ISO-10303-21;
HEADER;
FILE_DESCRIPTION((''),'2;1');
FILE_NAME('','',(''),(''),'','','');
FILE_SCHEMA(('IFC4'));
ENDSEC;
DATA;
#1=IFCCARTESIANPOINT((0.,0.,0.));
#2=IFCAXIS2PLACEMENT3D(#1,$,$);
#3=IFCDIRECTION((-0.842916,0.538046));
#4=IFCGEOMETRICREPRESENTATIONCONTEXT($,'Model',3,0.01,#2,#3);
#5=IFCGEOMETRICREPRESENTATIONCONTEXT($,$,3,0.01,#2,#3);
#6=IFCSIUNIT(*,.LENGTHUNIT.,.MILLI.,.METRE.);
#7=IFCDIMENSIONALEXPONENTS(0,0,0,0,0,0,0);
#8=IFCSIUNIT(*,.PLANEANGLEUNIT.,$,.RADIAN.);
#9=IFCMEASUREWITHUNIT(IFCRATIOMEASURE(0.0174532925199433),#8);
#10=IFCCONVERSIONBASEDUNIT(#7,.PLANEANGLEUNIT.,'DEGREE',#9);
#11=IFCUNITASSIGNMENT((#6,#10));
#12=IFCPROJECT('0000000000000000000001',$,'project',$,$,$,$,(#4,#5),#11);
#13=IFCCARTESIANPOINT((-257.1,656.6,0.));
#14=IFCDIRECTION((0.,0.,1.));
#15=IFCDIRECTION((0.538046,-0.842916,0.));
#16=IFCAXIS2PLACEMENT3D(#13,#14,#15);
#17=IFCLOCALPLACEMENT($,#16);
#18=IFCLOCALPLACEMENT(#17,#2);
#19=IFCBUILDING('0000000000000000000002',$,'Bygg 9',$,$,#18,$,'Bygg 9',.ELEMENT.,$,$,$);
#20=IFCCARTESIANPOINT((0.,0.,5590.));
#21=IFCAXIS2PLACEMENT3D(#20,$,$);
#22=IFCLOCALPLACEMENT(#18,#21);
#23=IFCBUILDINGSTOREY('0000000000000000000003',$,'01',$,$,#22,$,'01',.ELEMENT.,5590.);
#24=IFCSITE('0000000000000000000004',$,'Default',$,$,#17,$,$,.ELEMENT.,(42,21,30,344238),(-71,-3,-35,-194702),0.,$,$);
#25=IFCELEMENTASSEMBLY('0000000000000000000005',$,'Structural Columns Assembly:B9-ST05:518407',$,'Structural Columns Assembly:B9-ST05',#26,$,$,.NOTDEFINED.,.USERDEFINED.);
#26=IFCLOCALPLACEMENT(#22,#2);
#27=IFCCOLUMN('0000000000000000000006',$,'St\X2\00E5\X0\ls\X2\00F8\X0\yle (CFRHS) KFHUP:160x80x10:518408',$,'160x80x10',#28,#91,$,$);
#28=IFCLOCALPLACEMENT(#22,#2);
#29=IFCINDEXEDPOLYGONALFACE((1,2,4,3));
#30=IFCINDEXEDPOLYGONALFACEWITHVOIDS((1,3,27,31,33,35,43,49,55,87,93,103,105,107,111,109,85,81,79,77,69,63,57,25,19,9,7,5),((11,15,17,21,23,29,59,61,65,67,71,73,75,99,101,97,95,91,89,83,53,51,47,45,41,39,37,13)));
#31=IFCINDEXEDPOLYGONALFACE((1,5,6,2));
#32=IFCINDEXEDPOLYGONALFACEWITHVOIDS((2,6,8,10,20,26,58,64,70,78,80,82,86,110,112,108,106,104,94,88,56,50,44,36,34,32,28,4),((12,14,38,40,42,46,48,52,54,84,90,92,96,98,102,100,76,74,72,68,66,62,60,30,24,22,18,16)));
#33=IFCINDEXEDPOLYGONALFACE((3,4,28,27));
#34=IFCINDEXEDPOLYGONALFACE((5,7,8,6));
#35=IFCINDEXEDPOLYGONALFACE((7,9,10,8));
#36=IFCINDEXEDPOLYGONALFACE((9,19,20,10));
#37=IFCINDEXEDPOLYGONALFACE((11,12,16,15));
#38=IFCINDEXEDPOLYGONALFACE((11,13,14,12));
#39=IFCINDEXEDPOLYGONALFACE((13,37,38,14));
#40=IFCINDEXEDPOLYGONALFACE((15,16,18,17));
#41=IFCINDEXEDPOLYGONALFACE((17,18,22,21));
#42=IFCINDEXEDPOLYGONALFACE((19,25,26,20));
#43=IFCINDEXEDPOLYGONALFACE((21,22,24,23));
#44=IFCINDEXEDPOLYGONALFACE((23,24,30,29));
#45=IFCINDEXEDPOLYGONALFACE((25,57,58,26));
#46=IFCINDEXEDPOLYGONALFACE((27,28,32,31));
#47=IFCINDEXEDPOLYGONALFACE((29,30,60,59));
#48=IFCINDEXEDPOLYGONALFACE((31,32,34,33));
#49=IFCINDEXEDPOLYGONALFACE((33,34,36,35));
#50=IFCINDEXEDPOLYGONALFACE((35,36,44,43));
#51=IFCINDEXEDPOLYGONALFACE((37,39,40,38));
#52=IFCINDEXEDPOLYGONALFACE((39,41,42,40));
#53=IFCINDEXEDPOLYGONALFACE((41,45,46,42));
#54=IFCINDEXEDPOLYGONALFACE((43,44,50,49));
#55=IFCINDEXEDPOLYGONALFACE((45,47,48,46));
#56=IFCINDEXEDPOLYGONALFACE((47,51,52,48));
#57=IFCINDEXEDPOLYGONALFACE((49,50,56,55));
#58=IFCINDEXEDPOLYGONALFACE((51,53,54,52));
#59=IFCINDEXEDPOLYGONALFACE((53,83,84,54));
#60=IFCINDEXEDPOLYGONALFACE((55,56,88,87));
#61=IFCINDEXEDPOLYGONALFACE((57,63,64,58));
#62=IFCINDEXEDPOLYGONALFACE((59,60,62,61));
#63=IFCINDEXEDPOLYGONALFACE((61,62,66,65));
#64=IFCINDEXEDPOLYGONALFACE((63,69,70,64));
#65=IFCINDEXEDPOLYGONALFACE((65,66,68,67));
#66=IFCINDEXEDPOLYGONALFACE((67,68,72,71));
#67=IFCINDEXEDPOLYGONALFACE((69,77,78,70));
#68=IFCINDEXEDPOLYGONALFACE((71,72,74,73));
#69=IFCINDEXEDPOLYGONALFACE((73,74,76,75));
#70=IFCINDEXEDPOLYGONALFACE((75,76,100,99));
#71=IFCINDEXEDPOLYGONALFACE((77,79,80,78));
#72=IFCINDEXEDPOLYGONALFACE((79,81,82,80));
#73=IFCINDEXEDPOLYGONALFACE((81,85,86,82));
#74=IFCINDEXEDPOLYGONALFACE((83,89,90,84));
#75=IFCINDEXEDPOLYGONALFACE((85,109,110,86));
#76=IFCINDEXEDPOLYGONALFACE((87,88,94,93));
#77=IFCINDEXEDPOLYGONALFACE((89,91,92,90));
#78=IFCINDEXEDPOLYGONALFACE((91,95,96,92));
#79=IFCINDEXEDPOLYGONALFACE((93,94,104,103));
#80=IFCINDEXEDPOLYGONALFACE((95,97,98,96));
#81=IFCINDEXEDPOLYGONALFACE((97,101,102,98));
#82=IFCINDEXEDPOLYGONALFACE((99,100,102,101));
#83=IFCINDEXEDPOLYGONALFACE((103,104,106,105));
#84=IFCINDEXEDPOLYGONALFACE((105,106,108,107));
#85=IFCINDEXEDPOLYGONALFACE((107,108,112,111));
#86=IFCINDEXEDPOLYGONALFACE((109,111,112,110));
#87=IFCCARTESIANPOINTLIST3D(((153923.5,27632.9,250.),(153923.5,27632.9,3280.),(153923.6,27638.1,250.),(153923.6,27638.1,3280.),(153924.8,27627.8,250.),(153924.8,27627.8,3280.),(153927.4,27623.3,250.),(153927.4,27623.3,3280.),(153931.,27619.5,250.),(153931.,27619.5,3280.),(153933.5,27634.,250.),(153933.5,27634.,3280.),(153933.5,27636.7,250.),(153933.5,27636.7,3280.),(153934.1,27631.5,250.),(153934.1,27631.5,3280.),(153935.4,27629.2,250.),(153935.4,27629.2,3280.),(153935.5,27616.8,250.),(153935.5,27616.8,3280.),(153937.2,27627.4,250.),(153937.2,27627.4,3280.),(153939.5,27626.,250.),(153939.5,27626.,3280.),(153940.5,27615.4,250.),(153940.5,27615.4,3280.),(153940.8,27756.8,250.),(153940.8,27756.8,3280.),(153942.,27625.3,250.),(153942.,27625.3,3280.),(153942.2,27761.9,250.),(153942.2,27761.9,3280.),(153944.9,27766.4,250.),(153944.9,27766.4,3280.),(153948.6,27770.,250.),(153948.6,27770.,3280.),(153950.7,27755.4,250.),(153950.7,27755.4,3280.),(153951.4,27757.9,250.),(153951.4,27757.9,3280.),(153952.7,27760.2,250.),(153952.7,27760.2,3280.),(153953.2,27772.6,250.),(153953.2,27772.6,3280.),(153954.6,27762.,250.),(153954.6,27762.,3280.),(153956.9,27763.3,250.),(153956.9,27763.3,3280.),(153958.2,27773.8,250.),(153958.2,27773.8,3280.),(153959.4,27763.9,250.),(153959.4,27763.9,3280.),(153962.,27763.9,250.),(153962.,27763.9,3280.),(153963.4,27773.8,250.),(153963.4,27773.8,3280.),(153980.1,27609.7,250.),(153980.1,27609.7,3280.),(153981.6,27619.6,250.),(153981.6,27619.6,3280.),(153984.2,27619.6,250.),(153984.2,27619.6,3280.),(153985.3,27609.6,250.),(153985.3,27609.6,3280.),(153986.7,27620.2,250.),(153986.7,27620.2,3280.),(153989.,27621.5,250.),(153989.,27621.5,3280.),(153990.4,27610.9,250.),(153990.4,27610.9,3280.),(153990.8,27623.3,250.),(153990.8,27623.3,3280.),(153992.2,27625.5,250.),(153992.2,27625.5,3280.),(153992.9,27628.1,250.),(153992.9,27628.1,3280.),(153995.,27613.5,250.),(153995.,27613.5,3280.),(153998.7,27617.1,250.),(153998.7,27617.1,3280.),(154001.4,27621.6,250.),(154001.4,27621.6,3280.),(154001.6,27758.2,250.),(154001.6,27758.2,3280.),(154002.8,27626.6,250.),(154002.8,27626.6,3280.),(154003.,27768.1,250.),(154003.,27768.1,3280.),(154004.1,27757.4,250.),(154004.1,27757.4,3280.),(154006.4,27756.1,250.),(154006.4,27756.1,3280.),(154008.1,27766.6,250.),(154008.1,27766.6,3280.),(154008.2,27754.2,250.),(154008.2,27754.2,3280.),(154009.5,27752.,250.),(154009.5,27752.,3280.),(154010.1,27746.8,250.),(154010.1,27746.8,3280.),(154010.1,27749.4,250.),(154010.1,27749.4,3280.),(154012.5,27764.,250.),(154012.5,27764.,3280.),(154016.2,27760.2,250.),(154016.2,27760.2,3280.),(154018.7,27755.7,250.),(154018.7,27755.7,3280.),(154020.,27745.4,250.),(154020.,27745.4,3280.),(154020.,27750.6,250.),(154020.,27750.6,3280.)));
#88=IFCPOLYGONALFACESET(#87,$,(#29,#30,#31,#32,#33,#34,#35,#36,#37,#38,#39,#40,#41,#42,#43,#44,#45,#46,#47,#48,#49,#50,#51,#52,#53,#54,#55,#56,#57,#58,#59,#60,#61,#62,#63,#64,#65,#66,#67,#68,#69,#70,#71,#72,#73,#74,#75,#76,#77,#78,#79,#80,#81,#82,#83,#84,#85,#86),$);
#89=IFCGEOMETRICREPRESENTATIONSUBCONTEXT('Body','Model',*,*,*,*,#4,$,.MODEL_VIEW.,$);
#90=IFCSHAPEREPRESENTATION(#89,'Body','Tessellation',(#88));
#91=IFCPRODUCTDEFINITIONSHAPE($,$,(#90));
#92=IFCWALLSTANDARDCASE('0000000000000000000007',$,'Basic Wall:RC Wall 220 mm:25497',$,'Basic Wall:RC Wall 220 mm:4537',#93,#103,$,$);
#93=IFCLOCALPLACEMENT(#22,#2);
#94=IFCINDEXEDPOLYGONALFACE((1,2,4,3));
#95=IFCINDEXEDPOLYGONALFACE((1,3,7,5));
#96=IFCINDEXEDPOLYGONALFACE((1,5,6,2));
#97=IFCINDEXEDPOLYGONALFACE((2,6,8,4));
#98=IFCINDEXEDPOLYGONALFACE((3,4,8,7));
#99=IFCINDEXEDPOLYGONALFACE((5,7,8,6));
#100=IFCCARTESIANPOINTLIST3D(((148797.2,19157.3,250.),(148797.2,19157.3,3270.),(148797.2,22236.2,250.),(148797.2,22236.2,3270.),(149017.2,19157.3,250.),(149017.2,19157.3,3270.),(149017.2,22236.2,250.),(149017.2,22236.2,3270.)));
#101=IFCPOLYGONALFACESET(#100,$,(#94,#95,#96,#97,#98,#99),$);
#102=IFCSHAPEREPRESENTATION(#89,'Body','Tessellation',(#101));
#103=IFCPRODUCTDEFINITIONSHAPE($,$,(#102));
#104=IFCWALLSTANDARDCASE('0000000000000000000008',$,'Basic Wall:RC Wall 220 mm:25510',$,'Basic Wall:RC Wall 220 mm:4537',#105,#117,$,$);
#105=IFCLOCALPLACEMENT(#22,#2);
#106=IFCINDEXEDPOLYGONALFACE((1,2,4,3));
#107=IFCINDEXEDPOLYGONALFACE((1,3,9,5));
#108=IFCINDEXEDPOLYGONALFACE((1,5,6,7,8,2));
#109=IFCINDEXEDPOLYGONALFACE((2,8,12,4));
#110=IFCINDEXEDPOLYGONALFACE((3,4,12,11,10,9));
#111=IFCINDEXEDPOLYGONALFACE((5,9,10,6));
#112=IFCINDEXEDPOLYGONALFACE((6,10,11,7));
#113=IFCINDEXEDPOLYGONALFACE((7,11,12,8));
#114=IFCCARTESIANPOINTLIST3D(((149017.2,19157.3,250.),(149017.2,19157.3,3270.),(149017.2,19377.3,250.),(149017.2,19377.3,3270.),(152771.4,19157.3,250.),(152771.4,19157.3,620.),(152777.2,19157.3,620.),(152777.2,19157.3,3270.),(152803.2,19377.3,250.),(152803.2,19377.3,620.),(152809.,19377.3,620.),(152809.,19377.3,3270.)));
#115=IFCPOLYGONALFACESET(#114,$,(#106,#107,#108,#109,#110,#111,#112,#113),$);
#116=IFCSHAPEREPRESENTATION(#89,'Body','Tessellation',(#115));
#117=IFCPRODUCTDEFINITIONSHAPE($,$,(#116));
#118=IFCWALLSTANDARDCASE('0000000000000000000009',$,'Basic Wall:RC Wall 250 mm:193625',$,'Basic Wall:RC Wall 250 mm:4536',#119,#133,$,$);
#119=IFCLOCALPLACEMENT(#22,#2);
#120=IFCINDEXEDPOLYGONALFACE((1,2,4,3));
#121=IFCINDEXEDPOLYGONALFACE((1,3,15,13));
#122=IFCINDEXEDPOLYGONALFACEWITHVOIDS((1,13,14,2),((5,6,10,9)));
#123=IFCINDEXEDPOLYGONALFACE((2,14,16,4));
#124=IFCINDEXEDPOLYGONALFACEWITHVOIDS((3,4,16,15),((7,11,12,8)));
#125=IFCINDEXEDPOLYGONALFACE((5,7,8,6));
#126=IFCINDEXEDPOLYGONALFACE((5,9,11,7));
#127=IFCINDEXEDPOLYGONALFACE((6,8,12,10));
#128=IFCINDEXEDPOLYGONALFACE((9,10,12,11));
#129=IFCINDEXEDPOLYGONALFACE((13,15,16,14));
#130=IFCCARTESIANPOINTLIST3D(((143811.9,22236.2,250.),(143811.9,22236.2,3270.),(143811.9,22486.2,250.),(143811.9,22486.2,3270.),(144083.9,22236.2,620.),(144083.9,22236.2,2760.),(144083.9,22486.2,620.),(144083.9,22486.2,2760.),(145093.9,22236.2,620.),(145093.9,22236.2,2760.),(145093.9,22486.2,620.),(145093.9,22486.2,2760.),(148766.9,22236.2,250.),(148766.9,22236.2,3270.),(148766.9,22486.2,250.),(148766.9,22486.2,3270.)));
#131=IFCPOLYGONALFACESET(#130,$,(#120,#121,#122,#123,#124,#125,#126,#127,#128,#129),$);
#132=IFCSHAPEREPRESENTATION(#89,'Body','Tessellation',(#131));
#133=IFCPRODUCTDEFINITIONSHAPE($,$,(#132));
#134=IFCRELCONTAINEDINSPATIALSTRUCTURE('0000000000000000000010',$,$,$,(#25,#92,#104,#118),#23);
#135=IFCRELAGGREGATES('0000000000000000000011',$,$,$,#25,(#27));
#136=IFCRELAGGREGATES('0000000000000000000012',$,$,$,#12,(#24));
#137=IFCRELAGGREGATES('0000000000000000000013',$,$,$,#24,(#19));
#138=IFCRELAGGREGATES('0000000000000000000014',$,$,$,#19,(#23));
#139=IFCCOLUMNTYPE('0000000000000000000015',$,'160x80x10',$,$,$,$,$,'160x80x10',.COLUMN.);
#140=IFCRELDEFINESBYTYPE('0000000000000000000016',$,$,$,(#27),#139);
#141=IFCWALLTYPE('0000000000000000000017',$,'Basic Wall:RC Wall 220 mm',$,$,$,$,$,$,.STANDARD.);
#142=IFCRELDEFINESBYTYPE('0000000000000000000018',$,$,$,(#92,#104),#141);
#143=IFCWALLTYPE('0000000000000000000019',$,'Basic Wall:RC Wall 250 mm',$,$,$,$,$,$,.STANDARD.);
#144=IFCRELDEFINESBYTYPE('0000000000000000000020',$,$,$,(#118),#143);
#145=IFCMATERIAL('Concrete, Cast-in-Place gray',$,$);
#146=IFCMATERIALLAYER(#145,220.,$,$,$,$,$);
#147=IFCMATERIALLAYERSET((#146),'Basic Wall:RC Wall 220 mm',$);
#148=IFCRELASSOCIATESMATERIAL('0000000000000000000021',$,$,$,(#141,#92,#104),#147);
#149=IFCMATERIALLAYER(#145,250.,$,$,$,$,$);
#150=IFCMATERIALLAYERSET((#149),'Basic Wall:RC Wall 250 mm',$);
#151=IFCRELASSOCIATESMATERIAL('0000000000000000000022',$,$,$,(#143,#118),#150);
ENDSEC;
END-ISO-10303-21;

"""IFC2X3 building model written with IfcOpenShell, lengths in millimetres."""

from ifc_helpers import new_model, entity, si_unit, converted_unit, direction, frame, frame_2d, origin, origin_2d_with_axis, place, context, subcontext, project, spatial, polyline, circle_curve, parameter, trimmed, segment, composite_curve, rectangle, outline, extrude, clip, bounded_halfspace, source, transform, mapped, material, layer, layer_set, layer_usage, type_object, type_shapes, element, aggregate, save


model = new_model("IFC2X3")

# Units and contexts
model_context = context("Model", 3, precision=0.01, world=origin(), true_north=direction((-0.842916, 0.538046)))
context_of_model = context(None, 3, precision=0.01, world=origin(), true_north=direction((-0.842916, 0.538046)))
body_context = subcontext(model_context, "Body", "Model", "MODEL_VIEW")
ifc_project = project(units=[si_unit("LENGTHUNIT", "METRE", prefix="MILLI"), converted_unit("PLANEANGLEUNIT", "DEGREE", entity("IfcRatioMeasure", 0.0174532925199433), si_unit("PLANEANGLEUNIT", "RADIAN"), dimensions=[0, 0, 0, 0, 0, 0, 0])], contexts=[model_context, context_of_model])

# Site, building, storey
site_placement = place(None, frame((-257.1, 656.6, 0.0), z_axis=(0.0, 0.0, 1.0), x_axis=(0.538046, -0.842916, 0.0)))
site = spatial("IfcSite", under=ifc_project, at=site_placement, Name="Default", CompositionType="ELEMENT", RefLatitude=(42, 21, 30, 344238), RefLongitude=(-71, -3, -35, -194702), RefElevation=0.0)
building_placement = place(site_placement, origin())
building = spatial("IfcBuilding", under=site, at=building_placement, Name="Bygg 9", LongName="Bygg 9", CompositionType="ELEMENT")
storey_placement = place(building_placement, frame((0.0, 0.0, 5590.0)))
storey = spatial("IfcBuildingStorey", under=building, at=storey_placement, Name="01", LongName="01", CompositionType="ELEMENT", Elevation=5590.0)

# Element assembly, column
assembly_1_placement = place(storey_placement, origin())
assembly_1 = element("IfcElementAssembly", 1, at=assembly_1_placement, inside=storey, Name="Structural Columns Assembly:B9-ST05:518407", ObjectType="Structural Columns Assembly:B9-ST05", AssemblyPlace="NOTDEFINED", PredefinedType="USERDEFINED")
column_type_1 = type_object("IfcColumnType", Name="160x80x10", ElementType="160x80x10", PredefinedType="COLUMN")
shared_shape_1 = source(origin(), body_context, "Body", "SweptSolid", [
    extrude(outline(composite_curve([segment(trimmed(circle_curve(frame_2d((-20.0, 60.0), x_axis=(1.0, 0.0)), 20.0), [parameter(90.0)], [parameter(180.0)], True, "PARAMETER"), True, "CONTINUOUS"), segment(polyline([(-40.0, 60.0), (-40.0, -60.0)]), True, "CONTINUOUS"), segment(trimmed(circle_curve(frame_2d((-20.0, -60.0), x_axis=(1.0, 0.0)), 20.0), [parameter(180.0)], [parameter(270.0)], True, "PARAMETER"), True, "CONTINUOUS"), segment(polyline([(-20.0, -80.0), (20.0, -80.0)]), True, "CONTINUOUS"), segment(trimmed(circle_curve(frame_2d((20.0, -60.0), x_axis=(1.0, 0.0)), 20.0), [parameter(270.0)], [parameter(0.0)], True, "PARAMETER"), True, "CONTINUOUS"), segment(polyline([(40.0, -60.0), (40.0, 60.0)]), True, "CONTINUOUS"), segment(trimmed(circle_curve(frame_2d((20.0, 60.0), x_axis=(1.0, 0.0)), 20.0), [parameter(0.0)], [parameter(90.0)], True, "PARAMETER"), True, "CONTINUOUS"), segment(polyline([(20.0, 80.0), (-20.0, 80.0)]), True, "CONTINUOUS")], self_intersect=False), holes=[composite_curve([segment(polyline([(-20.0, 70.0), (20.0, 70.0)]), True, "CONTINUOUS"), segment(trimmed(circle_curve(frame_2d((20.0, 60.0), x_axis=(1.0, 0.0)), 10.0), [parameter(360.0)], [parameter(90.0)], True, "PARAMETER"), False, "CONTINUOUS"), segment(polyline([(30.0, 60.0), (30.0, -60.0)]), True, "CONTINUOUS"), segment(trimmed(circle_curve(frame_2d((20.0, -60.0), x_axis=(1.0, 0.0)), 10.0), [parameter(270.0)], [parameter(360.0)], True, "PARAMETER"), False, "CONTINUOUS"), segment(polyline([(20.0, -70.0), (-20.0, -70.0)]), True, "CONTINUOUS"), segment(trimmed(circle_curve(frame_2d((-20.0, -60.0), x_axis=(1.0, 0.0)), 10.0), [parameter(180.0)], [parameter(270.0)], True, "PARAMETER"), False, "CONTINUOUS"), segment(polyline([(-30.0, -60.0), (-30.0, 60.0)]), True, "CONTINUOUS"), segment(trimmed(circle_curve(frame_2d((-20.0, 60.0), x_axis=(1.0, 0.0)), 10.0), [parameter(90.0)], [parameter(180.0)], True, "PARAMETER"), False, "CONTINUOUS")], self_intersect=False)]), frame((41.6, 81.6, 0.0), z_axis=(0.0, 0.0, 1.0), x_axis=(-1.0, 0.0, 0.0)), (0.0, 0.0, 1.0), 3030.0),
])
type_shapes(column_type_1, [shared_shape_1])
column_1_placement = place(assembly_1_placement, frame((154024.6, 27766.5, 250.0), z_axis=(0.0, 0.0, 1.0), x_axis=(-0.989691, 0.143216, 0.0)))
column_1 = element("IfcColumn", 2, at=column_1_placement, type_object=column_type_1, Name="Stålsøyle (CFRHS) KFHUP:160x80x10:518408", ObjectType="160x80x10", context=body_context, shape_type="MappedRepresentation", body=[
    mapped(shared_shape_1, transform((0.0, 0.0, 0.0), scale=1.0)),
])

# Wall
ifc_material_1 = material(Name="Concrete, Cast-in-Place gray")
ifc_layer_1 = layer(ifc_material_1, 220.0)
ifc_layer_set_1 = layer_set([ifc_layer_1], Name="Basic Wall:RC Wall 220 mm")
ifc_layer_usage_1 = layer_usage(ifc_layer_set_1, "AXIS2", "NEGATIVE", 110.0)
wall_type_1 = type_object("IfcWallType", Name="Basic Wall:RC Wall 220 mm", PredefinedType="STANDARD", material=ifc_layer_set_1)
wall_1_placement = place(storey_placement, frame((148907.2, 19157.3, 250.0), z_axis=(0.0, 0.0, 1.0), x_axis=(0.0, 1.0, 0.0)))
element("IfcWallStandardCase", 3, at=wall_1_placement, inside=storey, type_object=wall_type_1, material=ifc_layer_usage_1, Name="Basic Wall:RC Wall 220 mm:25497", ObjectType="Basic Wall:RC Wall 220 mm:4537", context=body_context, shape_type="SweptSolid", body=[
    extrude(rectangle(XDim=3078.9, YDim=220.0, at=frame_2d((1539.4, 0.0), x_axis=(-1.0, 0.0))), origin(), (0.0, 0.0, 1.0), 3020.0),
])

# Walls, openings
ifc_layer_usage_2 = layer_usage(ifc_layer_set_1, "AXIS2", "NEGATIVE", 110.0)
wall_2_placement = place(storey_placement, frame((152809.0, 19267.3, 250.0), z_axis=(0.0, 0.0, 1.0), x_axis=(-1.0, 0.0, 0.0)))
wall_2 = element("IfcWallStandardCase", 4, at=wall_2_placement, inside=storey, type_object=wall_type_1, material=ifc_layer_usage_2, Name="Basic Wall:RC Wall 220 mm:25510", ObjectType="Basic Wall:RC Wall 220 mm:4537", context=body_context, shape_type="Clipping", body=[
    clip(clip(clip(extrude(rectangle(XDim=3791.9, YDim=220.0, at=frame_2d((1895.9, 0.0), x_axis=(-1.0, 0.0))), origin(), (0.0, 0.0, 1.0), 3020.0), bounded_halfspace(frame((3791.9, 110.0, 0.0)), True, frame((3791.9, 110.0, 0.0)), polyline([(0.0, 0.0), (-3754.2, 0.0), (-3786.0, -220.0), (0.0, -220.0), (0.0, 0.0)]))), bounded_halfspace(frame((3791.9, -110.0, 3020.0), z_axis=(0.0, 0.0, -1.0), x_axis=(-1.0, 0.0, 0.0)), True, frame((3791.9, -110.0, 3020.0)), polyline([(0.0, 0.0), (0.0, 220.0), (-3760.0, 220.0), (-3791.9, 0.0), (0.0, 0.0)]))), bounded_halfspace(frame((37.7, 110.0, 370.0), z_axis=(0.0, 0.0, -1.0), x_axis=(0.0, 1.0, 0.0)), False, frame((37.7, 110.0, 370.0)), polyline([(0.0, 0.0), (-5.8, 0.0), (-37.7, -220.0), (-31.8, -220.0), (0.0, 0.0)]))),
])
opening_1_placement = place(wall_2_placement, origin())
element("IfcOpeningElement", 5, at=opening_1_placement, cuts=wall_2, ObjectType="Opening", context=body_context, shape_type="SweptSolid", body=[
    extrude(rectangle(XDim=300.0, YDim=2186.0, at=origin_2d_with_axis()), frame((-258.0, -845.4, -104.2), z_axis=(0.0, 0.0, 1.0), x_axis=(-0.989691, 0.143216, 0.0)), (0.0, 0.0, 1.0), 15415.4),
])
ifc_layer_2 = layer(ifc_material_1, 250.0)
ifc_layer_set_2 = layer_set([ifc_layer_2], Name="Basic Wall:RC Wall 250 mm")
ifc_layer_usage_3 = layer_usage(ifc_layer_set_2, "AXIS2", "NEGATIVE", 125.0)
wall_type_2 = type_object("IfcWallType", Name="Basic Wall:RC Wall 250 mm", PredefinedType="STANDARD", material=ifc_layer_set_2)
wall_3_placement = place(storey_placement, frame((148766.9, 22361.2, 250.0), z_axis=(0.0, 0.0, 1.0), x_axis=(-1.0, 0.0, 0.0)))
wall_3 = element("IfcWallStandardCase", 6, at=wall_3_placement, inside=storey, type_object=wall_type_2, material=ifc_layer_usage_3, Name="Basic Wall:RC Wall 250 mm:193625", ObjectType="Basic Wall:RC Wall 250 mm:4536", context=body_context, shape_type="SweptSolid", body=[
    extrude(rectangle(XDim=4955.0, YDim=250.0, at=frame_2d((2477.5, 0.0), x_axis=(-1.0, 0.0))), origin(), (0.0, 0.0, 1.0), 3020.0),
])
opening_2_placement = place(wall_3_placement, origin())
element("IfcOpeningElement", 7, at=opening_2_placement, cuts=wall_3, ObjectType="Opening", context=body_context, shape_type="SweptSolid", body=[
    extrude(rectangle(XDim=2140.0, YDim=1010.0, at=origin_2d_with_axis()), frame((4178.0, -125.0, 1440.0), z_axis=(0.0, 1.0, 0.0), x_axis=(0.0, 0.0, -1.0)), (0.0, 0.0, 1.0), 250.0),
])

aggregate(assembly_1, [column_1])

save(model, "model.ifc")
